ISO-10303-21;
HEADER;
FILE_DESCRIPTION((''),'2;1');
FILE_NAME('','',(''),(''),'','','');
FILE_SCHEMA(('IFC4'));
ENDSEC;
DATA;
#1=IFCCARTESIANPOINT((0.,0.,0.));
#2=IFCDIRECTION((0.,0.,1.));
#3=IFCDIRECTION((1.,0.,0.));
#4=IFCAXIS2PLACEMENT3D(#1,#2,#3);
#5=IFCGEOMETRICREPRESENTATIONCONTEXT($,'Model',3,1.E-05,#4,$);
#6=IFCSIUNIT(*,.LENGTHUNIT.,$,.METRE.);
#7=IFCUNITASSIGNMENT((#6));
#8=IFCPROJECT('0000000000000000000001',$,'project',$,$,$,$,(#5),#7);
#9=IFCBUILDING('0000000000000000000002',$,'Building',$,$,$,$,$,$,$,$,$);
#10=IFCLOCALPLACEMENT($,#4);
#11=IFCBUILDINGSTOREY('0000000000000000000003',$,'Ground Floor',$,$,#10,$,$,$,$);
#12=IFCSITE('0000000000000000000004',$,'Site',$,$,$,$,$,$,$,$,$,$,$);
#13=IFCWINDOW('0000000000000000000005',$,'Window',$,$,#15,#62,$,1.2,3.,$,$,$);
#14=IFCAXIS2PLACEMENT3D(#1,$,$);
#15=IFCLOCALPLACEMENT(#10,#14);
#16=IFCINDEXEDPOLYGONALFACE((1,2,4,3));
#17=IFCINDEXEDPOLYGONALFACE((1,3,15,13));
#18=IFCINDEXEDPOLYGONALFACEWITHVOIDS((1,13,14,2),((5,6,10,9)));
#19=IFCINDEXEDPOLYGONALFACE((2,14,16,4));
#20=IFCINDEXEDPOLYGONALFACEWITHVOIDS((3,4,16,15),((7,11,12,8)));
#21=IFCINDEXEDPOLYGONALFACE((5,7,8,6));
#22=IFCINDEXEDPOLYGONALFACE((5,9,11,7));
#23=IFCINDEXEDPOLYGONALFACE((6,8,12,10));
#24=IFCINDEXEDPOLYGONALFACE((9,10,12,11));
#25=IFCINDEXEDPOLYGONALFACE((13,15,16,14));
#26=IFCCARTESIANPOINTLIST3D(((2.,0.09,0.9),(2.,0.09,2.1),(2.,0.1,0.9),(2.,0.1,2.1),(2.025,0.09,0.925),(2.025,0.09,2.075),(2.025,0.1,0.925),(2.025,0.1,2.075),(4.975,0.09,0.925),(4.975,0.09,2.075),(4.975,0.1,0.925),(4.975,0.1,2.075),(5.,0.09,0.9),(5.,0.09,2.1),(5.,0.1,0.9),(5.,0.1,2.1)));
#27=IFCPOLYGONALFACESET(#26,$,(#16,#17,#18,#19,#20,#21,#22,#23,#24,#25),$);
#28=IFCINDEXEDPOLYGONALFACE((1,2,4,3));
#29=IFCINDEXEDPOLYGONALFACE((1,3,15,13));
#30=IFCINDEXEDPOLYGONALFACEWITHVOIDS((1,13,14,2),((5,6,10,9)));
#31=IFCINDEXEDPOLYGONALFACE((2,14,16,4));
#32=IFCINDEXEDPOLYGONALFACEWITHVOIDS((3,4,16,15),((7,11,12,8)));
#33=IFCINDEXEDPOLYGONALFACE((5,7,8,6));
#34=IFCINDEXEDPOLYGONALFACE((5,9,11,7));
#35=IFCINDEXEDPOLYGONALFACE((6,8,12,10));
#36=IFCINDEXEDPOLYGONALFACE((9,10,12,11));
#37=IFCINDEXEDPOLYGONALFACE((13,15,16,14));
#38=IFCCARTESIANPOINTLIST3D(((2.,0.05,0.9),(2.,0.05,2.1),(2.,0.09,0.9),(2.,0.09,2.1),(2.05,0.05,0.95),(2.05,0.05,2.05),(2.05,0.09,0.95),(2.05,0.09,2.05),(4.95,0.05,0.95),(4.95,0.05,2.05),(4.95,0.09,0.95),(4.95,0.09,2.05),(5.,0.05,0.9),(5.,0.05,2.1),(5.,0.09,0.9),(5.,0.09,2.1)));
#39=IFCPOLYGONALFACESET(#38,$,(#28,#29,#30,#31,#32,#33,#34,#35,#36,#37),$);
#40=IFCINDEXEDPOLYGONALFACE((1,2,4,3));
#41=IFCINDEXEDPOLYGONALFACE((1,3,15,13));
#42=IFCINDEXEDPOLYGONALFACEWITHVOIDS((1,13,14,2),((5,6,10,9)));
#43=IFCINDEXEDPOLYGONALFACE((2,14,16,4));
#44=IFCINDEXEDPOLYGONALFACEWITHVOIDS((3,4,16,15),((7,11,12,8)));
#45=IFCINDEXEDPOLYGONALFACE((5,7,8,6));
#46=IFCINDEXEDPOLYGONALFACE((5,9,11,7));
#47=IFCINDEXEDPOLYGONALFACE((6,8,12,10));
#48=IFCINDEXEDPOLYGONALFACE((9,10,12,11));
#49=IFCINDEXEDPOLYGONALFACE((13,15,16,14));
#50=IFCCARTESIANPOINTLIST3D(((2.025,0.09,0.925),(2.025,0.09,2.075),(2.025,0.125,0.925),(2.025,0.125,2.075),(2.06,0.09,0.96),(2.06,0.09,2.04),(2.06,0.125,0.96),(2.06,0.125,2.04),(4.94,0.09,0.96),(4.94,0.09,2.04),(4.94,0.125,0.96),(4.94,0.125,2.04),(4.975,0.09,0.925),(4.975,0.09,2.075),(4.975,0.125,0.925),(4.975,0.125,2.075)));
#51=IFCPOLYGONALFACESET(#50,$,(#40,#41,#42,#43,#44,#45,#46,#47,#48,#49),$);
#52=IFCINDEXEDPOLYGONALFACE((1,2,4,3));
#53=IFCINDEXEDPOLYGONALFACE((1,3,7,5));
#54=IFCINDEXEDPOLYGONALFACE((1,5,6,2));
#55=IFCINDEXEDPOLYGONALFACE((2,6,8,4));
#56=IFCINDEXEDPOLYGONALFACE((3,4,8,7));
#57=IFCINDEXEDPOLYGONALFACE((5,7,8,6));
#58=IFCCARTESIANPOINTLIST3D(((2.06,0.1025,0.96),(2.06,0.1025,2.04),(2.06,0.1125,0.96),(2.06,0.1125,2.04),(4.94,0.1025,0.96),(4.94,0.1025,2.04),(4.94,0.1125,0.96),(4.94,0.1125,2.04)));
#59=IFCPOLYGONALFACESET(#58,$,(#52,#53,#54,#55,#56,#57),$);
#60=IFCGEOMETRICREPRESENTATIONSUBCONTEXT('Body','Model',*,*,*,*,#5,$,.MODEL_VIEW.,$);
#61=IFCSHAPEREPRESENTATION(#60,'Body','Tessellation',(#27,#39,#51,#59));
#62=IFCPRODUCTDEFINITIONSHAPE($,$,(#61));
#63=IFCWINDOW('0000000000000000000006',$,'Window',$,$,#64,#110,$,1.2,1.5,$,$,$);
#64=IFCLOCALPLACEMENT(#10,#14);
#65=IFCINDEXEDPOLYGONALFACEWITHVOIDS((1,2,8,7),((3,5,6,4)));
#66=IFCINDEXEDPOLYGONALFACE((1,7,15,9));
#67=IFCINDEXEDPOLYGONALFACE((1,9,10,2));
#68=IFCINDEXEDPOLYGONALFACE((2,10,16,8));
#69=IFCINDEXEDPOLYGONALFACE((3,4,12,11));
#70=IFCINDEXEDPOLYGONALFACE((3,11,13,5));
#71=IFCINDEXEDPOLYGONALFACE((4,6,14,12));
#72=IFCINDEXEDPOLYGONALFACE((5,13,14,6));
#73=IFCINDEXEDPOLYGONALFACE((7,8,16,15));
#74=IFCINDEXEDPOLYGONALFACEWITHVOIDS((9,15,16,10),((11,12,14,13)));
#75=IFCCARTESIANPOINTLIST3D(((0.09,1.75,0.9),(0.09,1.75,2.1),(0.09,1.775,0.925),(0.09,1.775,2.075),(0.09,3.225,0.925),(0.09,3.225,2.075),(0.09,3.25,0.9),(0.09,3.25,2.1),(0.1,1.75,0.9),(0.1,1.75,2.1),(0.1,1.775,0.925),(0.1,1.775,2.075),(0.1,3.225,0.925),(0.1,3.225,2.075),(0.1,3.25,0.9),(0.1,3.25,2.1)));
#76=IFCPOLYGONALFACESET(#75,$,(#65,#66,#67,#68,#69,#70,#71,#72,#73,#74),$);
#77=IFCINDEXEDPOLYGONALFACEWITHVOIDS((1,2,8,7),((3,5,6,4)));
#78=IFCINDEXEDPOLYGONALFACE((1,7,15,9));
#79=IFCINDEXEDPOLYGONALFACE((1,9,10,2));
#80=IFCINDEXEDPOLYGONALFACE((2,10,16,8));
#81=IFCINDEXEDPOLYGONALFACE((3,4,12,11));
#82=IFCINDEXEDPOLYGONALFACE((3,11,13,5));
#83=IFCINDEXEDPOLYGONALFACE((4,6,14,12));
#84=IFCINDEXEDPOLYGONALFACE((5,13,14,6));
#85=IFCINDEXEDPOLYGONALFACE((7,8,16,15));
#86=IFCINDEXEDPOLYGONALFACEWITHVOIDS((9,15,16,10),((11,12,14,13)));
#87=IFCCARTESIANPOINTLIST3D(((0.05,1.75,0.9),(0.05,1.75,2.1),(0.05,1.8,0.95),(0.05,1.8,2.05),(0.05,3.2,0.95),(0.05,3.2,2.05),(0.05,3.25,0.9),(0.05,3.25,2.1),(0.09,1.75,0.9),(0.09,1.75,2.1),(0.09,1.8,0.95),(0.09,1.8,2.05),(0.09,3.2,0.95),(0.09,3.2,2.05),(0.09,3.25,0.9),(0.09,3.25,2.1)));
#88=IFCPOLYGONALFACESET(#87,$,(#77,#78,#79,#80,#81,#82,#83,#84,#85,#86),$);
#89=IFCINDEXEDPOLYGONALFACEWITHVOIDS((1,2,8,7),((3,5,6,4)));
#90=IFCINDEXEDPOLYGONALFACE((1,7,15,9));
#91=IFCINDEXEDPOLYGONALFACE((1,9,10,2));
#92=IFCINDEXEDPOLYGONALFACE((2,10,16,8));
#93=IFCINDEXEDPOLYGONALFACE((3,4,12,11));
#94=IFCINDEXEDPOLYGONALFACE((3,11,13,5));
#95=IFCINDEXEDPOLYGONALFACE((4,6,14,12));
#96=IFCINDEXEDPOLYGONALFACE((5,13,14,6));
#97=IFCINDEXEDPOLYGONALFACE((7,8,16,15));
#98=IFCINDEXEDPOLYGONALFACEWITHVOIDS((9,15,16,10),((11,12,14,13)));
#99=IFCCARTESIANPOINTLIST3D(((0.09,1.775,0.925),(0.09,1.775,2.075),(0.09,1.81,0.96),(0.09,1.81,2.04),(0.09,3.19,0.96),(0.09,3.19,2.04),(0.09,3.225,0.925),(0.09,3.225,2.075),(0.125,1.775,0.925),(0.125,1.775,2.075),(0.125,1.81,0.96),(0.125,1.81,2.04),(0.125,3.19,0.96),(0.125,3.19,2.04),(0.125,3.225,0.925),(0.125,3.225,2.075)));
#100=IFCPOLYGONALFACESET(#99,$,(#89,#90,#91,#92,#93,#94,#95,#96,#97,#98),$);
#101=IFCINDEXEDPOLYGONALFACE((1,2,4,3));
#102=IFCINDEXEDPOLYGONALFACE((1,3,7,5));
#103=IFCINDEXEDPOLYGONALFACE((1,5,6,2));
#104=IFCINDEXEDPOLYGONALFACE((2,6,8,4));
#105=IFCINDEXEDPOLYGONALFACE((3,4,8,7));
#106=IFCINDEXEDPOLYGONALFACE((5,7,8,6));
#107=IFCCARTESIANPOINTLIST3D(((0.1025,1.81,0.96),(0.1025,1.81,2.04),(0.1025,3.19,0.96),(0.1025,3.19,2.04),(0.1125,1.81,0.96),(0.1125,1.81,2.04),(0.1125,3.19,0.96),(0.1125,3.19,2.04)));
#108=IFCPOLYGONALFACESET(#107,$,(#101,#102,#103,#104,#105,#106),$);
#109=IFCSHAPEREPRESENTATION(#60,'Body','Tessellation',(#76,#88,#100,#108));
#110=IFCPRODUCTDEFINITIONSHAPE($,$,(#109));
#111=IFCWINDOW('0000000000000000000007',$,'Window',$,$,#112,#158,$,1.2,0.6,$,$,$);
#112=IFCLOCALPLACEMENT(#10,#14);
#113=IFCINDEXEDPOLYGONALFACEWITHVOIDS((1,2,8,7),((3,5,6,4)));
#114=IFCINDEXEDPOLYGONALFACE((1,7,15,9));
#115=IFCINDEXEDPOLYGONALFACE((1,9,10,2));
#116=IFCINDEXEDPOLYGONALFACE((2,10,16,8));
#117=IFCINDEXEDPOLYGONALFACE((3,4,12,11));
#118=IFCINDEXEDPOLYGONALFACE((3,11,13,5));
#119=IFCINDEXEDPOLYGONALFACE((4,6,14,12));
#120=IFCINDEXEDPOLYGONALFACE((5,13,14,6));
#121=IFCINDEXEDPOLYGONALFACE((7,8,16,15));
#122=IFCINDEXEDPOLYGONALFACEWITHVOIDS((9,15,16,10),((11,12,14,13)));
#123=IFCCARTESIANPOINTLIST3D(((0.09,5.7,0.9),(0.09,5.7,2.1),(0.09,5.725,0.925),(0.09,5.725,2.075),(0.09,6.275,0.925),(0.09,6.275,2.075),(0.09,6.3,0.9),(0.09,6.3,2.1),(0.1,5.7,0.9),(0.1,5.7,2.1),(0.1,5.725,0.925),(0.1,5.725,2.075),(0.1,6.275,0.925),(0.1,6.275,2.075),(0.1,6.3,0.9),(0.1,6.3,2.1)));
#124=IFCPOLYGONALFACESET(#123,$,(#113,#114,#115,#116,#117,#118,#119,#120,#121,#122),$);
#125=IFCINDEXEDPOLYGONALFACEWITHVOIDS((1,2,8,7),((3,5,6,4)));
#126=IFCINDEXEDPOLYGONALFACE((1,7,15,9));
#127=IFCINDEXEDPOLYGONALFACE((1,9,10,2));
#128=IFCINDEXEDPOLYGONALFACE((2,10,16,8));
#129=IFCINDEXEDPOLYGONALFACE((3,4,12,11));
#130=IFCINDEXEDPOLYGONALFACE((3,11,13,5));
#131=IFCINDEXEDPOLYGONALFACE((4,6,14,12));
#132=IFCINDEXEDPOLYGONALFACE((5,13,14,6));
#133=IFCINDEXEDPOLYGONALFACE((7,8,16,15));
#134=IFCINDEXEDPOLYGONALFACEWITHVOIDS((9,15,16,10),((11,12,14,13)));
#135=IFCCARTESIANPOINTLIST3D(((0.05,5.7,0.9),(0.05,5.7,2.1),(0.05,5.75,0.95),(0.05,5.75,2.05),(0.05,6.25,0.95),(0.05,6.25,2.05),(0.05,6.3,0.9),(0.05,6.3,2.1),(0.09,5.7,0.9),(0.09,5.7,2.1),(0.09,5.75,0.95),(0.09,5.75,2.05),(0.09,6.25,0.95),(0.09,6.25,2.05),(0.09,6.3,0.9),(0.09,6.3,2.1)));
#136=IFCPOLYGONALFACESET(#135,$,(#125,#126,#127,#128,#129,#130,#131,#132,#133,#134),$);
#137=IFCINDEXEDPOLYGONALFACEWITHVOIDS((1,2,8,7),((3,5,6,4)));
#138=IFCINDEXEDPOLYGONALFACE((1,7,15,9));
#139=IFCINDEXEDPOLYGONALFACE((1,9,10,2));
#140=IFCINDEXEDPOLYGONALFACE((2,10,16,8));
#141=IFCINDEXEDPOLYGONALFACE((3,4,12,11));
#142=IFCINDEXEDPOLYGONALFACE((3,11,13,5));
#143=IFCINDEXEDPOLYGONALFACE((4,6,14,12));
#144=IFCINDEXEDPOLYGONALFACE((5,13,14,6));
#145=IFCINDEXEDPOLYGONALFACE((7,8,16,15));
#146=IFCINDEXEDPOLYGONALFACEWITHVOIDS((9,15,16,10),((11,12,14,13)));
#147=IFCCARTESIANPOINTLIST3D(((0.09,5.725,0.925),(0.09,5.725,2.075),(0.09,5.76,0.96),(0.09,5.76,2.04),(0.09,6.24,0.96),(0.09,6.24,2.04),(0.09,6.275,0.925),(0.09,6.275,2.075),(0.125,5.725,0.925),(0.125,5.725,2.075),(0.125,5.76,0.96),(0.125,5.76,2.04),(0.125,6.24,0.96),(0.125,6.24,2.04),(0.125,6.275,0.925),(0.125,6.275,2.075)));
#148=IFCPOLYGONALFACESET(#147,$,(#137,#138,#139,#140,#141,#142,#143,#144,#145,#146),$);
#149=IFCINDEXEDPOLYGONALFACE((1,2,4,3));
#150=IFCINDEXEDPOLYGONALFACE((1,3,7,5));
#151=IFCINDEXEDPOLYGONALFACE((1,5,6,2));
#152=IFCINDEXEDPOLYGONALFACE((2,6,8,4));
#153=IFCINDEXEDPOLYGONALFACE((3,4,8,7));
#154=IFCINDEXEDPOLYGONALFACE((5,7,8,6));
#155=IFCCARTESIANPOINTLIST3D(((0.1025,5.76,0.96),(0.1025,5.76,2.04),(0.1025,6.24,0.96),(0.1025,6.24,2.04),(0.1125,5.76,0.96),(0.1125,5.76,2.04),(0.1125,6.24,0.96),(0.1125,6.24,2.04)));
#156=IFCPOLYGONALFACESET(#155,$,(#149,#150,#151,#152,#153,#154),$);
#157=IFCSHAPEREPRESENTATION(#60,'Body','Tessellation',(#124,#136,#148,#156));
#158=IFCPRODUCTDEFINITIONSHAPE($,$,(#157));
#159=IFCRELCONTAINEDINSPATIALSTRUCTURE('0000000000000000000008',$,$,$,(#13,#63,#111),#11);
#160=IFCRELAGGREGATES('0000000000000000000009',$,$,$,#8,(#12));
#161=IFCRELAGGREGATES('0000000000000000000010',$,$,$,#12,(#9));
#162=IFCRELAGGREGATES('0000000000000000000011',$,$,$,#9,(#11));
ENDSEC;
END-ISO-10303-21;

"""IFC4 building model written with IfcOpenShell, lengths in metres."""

from ifc_helpers import new_model, si_unit, frame, origin_with_axes, place, context, subcontext, project, spatial, line, indexed_curve, outline, extrude, element, save


model = new_model("IFC4")

# Units and contexts
model_context = context("Model", 3, precision=1e-05, world=origin_with_axes())
body_context = subcontext(model_context, "Body", "Model", "MODEL_VIEW")
ifc_project = project(units=[si_unit("LENGTHUNIT", "METRE")], contexts=[model_context])

# Site, building, storey
site = spatial("IfcSite", under=ifc_project, Name="Site")
building = spatial("IfcBuilding", under=site, Name="Building")
storey_placement = place(None, origin_with_axes())
storey = spatial("IfcBuildingStorey", under=building, at=storey_placement, Name="Ground Floor")

# Windows
window_1_placement = place(storey_placement, frame((2.0, 0.0, 0.9), z_axis=(0.0, 0.0, 1.0), x_axis=(1.0, 0.0, 0.0)))
element("IfcWindow", 1, at=window_1_placement, inside=storey, Name="Window", OverallHeight=1.2, OverallWidth=3.0, context=body_context, shape_type="SweptSolid", body=[
    extrude(outline(indexed_curve([(0.0, 0.0), (3.0, 0.0), (3.0, 1.2), (0.0, 1.2)], segments=[line(1, 2, 3, 4, 1)]), holes=[indexed_curve([(0.025, 0.025), (2.975, 0.025), (2.975, 1.175), (0.025, 1.175)], segments=[line(1, 2, 3, 4, 1)])]), frame((0.0, 0.09, 0.0), z_axis=(0.0, -1.0, 0.0), x_axis=(1.0, 0.0, 0.0)), (0.0, 0.0, -1.0), 0.01),
    extrude(outline(indexed_curve([(0.0, 0.0), (3.0, 0.0), (3.0, 1.2), (0.0, 1.2)], segments=[line(1, 2, 3, 4, 1)]), holes=[indexed_curve([(0.05, 0.05), (2.95, 0.05), (2.95, 1.15), (0.05, 1.15)], segments=[line(1, 2, 3, 4, 1)])]), frame((0.0, 0.05, 0.0), z_axis=(0.0, -1.0, 0.0), x_axis=(1.0, 0.0, 0.0)), (0.0, 0.0, -1.0), 0.04),
    extrude(outline(indexed_curve([(0.0, 0.0), (2.95, 0.0), (2.95, 1.15), (0.0, 1.15)], segments=[line(1, 2, 3, 4, 1)]), holes=[indexed_curve([(0.035, 0.035), (2.915, 0.035), (2.915, 1.115), (0.035, 1.115)], segments=[line(1, 2, 3, 4, 1)])]), frame((0.025, 0.09, 0.025), z_axis=(0.0, -1.0, 0.0), x_axis=(1.0, 0.0, 0.0)), (0.0, 0.0, -1.0), 0.035),
    extrude(outline(indexed_curve([(0.035, 0.035), (2.915, 0.035), (2.915, 1.115), (0.035, 1.115)], segments=[line(1, 2, 3, 4, 1)])), frame((0.025, 0.1025, 0.025), z_axis=(0.0, -1.0, 0.0), x_axis=(1.0, 0.0, 0.0)), (0.0, 0.0, -1.0), 0.01),
])
window_2_placement = place(storey_placement, frame((0.0, 3.25, 0.9), z_axis=(0.0, 0.0, 1.0), x_axis=(0.0, -1.0, 0.0)))
element("IfcWindow", 2, at=window_2_placement, inside=storey, Name="Window", OverallHeight=1.2, OverallWidth=1.5, context=body_context, shape_type="SweptSolid", body=[
    extrude(outline(indexed_curve([(0.0, 0.0), (1.5, 0.0), (1.5, 1.2), (0.0, 1.2)], segments=[line(1, 2, 3, 4, 1)]), holes=[indexed_curve([(0.025, 0.025), (1.475, 0.025), (1.475, 1.175), (0.025, 1.175)], segments=[line(1, 2, 3, 4, 1)])]), frame((0.0, 0.09, 0.0), z_axis=(0.0, -1.0, 0.0), x_axis=(1.0, 0.0, 0.0)), (0.0, 0.0, -1.0), 0.01),
    extrude(outline(indexed_curve([(0.0, 0.0), (1.5, 0.0), (1.5, 1.2), (0.0, 1.2)], segments=[line(1, 2, 3, 4, 1)]), holes=[indexed_curve([(0.05, 0.05), (1.45, 0.05), (1.45, 1.15), (0.05, 1.15)], segments=[line(1, 2, 3, 4, 1)])]), frame((0.0, 0.05, 0.0), z_axis=(0.0, -1.0, 0.0), x_axis=(1.0, 0.0, 0.0)), (0.0, 0.0, -1.0), 0.04),
    extrude(outline(indexed_curve([(0.0, 0.0), (1.45, 0.0), (1.45, 1.15), (0.0, 1.15)], segments=[line(1, 2, 3, 4, 1)]), holes=[indexed_curve([(0.035, 0.035), (1.415, 0.035), (1.415, 1.115), (0.035, 1.115)], segments=[line(1, 2, 3, 4, 1)])]), frame((0.025, 0.09, 0.025), z_axis=(0.0, -1.0, 0.0), x_axis=(1.0, 0.0, 0.0)), (0.0, 0.0, -1.0), 0.035),
    extrude(outline(indexed_curve([(0.035, 0.035), (1.415, 0.035), (1.415, 1.115), (0.035, 1.115)], segments=[line(1, 2, 3, 4, 1)])), frame((0.025, 0.1025, 0.025), z_axis=(0.0, -1.0, 0.0), x_axis=(1.0, 0.0, 0.0)), (0.0, 0.0, -1.0), 0.01),
])
window_3_placement = place(storey_placement, frame((0.0, 6.3, 0.9), z_axis=(0.0, 0.0, 1.0), x_axis=(0.0, -1.0, 0.0)))
element("IfcWindow", 3, at=window_3_placement, inside=storey, Name="Window", OverallHeight=1.2, OverallWidth=0.6, context=body_context, shape_type="SweptSolid", body=[
    extrude(outline(indexed_curve([(0.0, 0.0), (0.6, 0.0), (0.6, 1.2), (0.0, 1.2)], segments=[line(1, 2, 3, 4, 1)]), holes=[indexed_curve([(0.025, 0.025), (0.575, 0.025), (0.575, 1.175), (0.025, 1.175)], segments=[line(1, 2, 3, 4, 1)])]), frame((0.0, 0.09, 0.0), z_axis=(0.0, -1.0, 0.0), x_axis=(1.0, 0.0, 0.0)), (0.0, 0.0, -1.0), 0.01),
    extrude(outline(indexed_curve([(0.0, 0.0), (0.6, 0.0), (0.6, 1.2), (0.0, 1.2)], segments=[line(1, 2, 3, 4, 1)]), holes=[indexed_curve([(0.05, 0.05), (0.55, 0.05), (0.55, 1.15), (0.05, 1.15)], segments=[line(1, 2, 3, 4, 1)])]), frame((0.0, 0.05, 0.0), z_axis=(0.0, -1.0, 0.0), x_axis=(1.0, 0.0, 0.0)), (0.0, 0.0, -1.0), 0.04),
    extrude(outline(indexed_curve([(0.0, 0.0), (0.55, 0.0), (0.55, 1.15), (0.0, 1.15)], segments=[line(1, 2, 3, 4, 1)]), holes=[indexed_curve([(0.035, 0.035), (0.515, 0.035), (0.515, 1.115), (0.035, 1.115)], segments=[line(1, 2, 3, 4, 1)])]), frame((0.025, 0.09, 0.025), z_axis=(0.0, -1.0, 0.0), x_axis=(1.0, 0.0, 0.0)), (0.0, 0.0, -1.0), 0.035),
    extrude(outline(indexed_curve([(0.035, 0.035), (0.515, 0.035), (0.515, 1.115), (0.035, 1.115)], segments=[line(1, 2, 3, 4, 1)])), frame((0.025, 0.1025, 0.025), z_axis=(0.0, -1.0, 0.0), x_axis=(1.0, 0.0, 0.0)), (0.0, 0.0, -1.0), 0.01),
])

save(model, "model.ifc")
